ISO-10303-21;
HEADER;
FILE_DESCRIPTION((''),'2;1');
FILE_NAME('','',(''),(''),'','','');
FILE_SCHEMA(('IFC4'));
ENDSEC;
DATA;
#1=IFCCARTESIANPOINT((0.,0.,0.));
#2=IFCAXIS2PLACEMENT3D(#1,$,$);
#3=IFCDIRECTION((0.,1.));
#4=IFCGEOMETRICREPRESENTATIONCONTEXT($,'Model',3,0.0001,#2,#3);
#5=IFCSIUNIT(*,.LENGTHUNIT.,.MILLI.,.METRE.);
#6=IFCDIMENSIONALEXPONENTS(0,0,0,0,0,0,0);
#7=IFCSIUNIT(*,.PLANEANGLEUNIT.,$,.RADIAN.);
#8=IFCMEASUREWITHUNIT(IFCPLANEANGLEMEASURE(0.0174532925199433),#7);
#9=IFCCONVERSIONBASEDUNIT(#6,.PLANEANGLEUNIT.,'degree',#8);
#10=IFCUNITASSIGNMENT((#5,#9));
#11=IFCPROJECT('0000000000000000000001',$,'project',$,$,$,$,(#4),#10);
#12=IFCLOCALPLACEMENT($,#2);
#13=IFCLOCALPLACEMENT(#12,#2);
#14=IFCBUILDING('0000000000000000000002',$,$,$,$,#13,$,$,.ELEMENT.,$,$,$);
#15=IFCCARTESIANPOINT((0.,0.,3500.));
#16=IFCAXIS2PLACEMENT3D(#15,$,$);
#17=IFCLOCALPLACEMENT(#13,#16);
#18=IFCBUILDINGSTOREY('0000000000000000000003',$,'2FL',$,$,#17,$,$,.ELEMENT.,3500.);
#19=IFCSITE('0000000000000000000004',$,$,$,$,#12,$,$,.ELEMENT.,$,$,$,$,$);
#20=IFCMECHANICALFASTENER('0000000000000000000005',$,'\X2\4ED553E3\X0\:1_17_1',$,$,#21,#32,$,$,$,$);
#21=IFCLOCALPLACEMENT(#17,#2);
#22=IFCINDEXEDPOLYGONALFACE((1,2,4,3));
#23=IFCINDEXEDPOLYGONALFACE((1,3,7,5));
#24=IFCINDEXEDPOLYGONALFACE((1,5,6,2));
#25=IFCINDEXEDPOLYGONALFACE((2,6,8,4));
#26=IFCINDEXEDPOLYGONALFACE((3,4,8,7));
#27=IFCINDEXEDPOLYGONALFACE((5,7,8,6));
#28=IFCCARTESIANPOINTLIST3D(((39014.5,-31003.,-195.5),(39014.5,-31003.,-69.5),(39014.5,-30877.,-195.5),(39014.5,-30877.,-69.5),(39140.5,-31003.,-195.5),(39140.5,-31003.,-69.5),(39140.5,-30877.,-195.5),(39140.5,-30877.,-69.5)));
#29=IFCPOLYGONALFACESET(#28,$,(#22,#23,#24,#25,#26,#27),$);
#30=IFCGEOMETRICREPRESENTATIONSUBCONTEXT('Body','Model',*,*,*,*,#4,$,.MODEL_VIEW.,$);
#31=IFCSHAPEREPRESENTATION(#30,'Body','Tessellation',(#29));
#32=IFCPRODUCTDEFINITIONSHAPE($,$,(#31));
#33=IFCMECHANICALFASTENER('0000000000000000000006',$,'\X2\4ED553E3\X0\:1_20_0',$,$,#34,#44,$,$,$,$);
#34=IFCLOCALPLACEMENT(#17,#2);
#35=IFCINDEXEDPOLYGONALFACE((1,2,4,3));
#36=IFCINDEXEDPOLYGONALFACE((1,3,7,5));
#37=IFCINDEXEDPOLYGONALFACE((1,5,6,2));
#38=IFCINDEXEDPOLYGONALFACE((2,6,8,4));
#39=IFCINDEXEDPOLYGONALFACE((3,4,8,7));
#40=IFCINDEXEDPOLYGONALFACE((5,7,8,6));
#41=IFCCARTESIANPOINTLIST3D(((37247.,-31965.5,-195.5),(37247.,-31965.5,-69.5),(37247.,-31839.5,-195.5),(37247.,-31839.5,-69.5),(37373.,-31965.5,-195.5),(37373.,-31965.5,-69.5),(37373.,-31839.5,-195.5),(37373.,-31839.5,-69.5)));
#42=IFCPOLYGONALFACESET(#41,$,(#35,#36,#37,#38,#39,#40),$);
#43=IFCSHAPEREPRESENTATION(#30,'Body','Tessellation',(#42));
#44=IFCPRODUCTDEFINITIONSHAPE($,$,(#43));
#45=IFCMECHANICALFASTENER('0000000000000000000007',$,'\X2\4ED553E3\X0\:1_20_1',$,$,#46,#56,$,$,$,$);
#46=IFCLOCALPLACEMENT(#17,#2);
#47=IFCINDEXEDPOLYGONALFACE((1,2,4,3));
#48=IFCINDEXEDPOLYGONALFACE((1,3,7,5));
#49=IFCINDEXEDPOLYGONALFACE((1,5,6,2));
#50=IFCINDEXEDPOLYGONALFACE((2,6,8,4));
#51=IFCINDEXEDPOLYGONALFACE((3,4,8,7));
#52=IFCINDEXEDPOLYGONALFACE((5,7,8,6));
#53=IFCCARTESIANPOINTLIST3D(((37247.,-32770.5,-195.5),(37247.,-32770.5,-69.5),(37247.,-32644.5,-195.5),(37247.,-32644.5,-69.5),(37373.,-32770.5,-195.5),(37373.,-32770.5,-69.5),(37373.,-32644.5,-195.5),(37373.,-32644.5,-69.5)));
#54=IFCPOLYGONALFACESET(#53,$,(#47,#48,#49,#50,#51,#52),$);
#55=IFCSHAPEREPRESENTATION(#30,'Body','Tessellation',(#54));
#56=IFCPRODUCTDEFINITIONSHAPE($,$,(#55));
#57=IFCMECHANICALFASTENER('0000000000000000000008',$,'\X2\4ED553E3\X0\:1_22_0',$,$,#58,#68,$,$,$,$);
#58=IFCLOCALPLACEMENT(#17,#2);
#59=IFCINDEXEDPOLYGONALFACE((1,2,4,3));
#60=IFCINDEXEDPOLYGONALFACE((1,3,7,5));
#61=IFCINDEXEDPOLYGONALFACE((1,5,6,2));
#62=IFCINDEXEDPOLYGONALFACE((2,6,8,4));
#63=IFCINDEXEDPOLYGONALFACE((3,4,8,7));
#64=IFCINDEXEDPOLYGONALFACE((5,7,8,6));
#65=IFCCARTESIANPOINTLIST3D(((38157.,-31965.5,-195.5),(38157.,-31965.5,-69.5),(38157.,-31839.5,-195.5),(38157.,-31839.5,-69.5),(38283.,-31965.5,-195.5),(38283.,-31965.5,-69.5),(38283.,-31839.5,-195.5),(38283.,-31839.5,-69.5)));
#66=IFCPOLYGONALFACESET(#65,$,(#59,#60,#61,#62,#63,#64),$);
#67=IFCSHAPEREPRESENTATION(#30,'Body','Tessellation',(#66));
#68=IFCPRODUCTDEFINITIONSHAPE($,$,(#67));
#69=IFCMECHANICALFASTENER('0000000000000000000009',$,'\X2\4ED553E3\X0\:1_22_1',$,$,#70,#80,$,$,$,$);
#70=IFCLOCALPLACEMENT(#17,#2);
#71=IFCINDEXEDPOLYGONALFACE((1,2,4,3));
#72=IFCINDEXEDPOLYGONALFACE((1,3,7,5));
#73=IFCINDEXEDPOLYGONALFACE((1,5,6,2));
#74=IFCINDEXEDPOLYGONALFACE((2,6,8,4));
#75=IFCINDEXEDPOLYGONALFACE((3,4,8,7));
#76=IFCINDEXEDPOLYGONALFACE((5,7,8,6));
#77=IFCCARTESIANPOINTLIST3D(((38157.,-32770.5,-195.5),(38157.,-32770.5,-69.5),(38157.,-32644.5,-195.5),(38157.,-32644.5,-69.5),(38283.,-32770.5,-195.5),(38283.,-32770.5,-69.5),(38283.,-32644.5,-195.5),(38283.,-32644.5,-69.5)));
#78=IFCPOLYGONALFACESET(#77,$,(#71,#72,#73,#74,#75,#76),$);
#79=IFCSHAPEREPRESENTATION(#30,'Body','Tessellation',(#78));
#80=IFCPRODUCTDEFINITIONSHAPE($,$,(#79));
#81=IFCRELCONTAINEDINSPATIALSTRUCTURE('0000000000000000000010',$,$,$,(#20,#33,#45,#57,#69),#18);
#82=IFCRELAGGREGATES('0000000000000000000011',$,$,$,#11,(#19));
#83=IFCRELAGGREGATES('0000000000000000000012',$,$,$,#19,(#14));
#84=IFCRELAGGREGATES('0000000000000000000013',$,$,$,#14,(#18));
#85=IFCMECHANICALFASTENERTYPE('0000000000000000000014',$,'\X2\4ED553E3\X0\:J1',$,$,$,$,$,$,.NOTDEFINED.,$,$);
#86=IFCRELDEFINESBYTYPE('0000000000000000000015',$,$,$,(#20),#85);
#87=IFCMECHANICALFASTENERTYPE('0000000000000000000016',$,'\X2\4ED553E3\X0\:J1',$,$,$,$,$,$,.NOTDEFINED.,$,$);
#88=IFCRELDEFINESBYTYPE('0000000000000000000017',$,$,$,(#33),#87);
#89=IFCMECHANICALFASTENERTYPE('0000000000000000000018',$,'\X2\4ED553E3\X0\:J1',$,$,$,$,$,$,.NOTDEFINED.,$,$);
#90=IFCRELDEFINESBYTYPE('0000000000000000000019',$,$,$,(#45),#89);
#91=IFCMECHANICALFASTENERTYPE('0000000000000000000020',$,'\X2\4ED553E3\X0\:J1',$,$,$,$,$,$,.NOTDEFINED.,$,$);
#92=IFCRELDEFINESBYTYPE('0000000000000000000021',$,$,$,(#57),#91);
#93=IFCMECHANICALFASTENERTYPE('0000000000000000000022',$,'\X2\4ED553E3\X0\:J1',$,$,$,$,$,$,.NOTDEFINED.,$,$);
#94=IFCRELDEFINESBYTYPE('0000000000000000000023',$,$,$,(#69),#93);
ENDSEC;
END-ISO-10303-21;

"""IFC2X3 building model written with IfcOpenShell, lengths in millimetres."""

from ifc_helpers import new_model, entity, si_unit, converted_unit, direction, frame, origin, origin_with_axes, origin_2d, place, context, subcontext, project, spatial, rectangle, extrude, type_object, element, save


model = new_model("IFC2X3")

# Units and contexts
model_context = context("Model", 3, precision=0.0001, world=origin(), true_north=direction((0.0, 1.0)))
body_context = subcontext(model_context, "Body", "Model", "MODEL_VIEW")
ifc_project = project(units=[si_unit("LENGTHUNIT", "METRE", prefix="MILLI"), converted_unit("PLANEANGLEUNIT", "degree", entity("IfcPlaneAngleMeasure", 0.0174532925199433), si_unit("PLANEANGLEUNIT", "RADIAN"), dimensions=[0, 0, 0, 0, 0, 0, 0])], contexts=[model_context])

# Site, building, storey
site_placement = place(None, origin())
site = spatial("IfcSite", under=ifc_project, at=site_placement, CompositionType="ELEMENT")
building_placement = place(site_placement, origin())
building = spatial("IfcBuilding", under=site, at=building_placement, CompositionType="ELEMENT")
storey_placement = place(building_placement, frame((0.0, 0.0, 3500.0)))
storey = spatial("IfcBuildingStorey", under=building, at=storey_placement, Name="2FL", CompositionType="ELEMENT", Elevation=3500.0)

# Mechanical fasteners
mechanical_fastener_type_1 = type_object("IfcMechanicalFastenerType", Name="仕口:J1")
mechanical_fastener_1_placement = place(storey_placement, frame((39077.5, -30940.0, -195.5)))
element("IfcMechanicalFastener", 1, at=mechanical_fastener_1_placement, inside=storey, type_object=mechanical_fastener_type_1, Name="仕口:1_17_1", context=body_context, shape_type="SweptSolid", body=[
    extrude(rectangle(XDim=126.0, YDim=126.0, at=origin_2d()), origin_with_axes(), (0.0, 0.0, 1.0), 126.0),
])
mechanical_fastener_type_2 = type_object("IfcMechanicalFastenerType", Name="仕口:J1")
mechanical_fastener_2_placement = place(storey_placement, frame((37310.0, -31902.5, -195.5)))
element("IfcMechanicalFastener", 2, at=mechanical_fastener_2_placement, inside=storey, type_object=mechanical_fastener_type_2, Name="仕口:1_20_0", context=body_context, shape_type="SweptSolid", body=[
    extrude(rectangle(XDim=126.0, YDim=126.0, at=origin_2d()), origin_with_axes(), (0.0, 0.0, 1.0), 126.0),
])
mechanical_fastener_type_3 = type_object("IfcMechanicalFastenerType", Name="仕口:J1")
mechanical_fastener_3_placement = place(storey_placement, frame((37310.0, -32707.5, -195.5)))
element("IfcMechanicalFastener", 3, at=mechanical_fastener_3_placement, inside=storey, type_object=mechanical_fastener_type_3, Name="仕口:1_20_1", context=body_context, shape_type="SweptSolid", body=[
    extrude(rectangle(XDim=126.0, YDim=126.0, at=origin_2d()), origin_with_axes(), (0.0, 0.0, 1.0), 126.0),
])
mechanical_fastener_type_4 = type_object("IfcMechanicalFastenerType", Name="仕口:J1")
mechanical_fastener_4_placement = place(storey_placement, frame((38220.0, -31902.5, -195.5)))
element("IfcMechanicalFastener", 4, at=mechanical_fastener_4_placement, inside=storey, type_object=mechanical_fastener_type_4, Name="仕口:1_22_0", context=body_context, shape_type="SweptSolid", body=[
    extrude(rectangle(XDim=126.0, YDim=126.0, at=origin_2d()), origin_with_axes(), (0.0, 0.0, 1.0), 126.0),
])
mechanical_fastener_type_5 = type_object("IfcMechanicalFastenerType", Name="仕口:J1")
mechanical_fastener_5_placement = place(storey_placement, frame((38220.0, -32707.5, -195.5)))
element("IfcMechanicalFastener", 5, at=mechanical_fastener_5_placement, inside=storey, type_object=mechanical_fastener_type_5, Name="仕口:1_22_1", context=body_context, shape_type="SweptSolid", body=[
    extrude(rectangle(XDim=126.0, YDim=126.0, at=origin_2d()), origin_with_axes(), (0.0, 0.0, 1.0), 126.0),
])

save(model, "model.ifc")
